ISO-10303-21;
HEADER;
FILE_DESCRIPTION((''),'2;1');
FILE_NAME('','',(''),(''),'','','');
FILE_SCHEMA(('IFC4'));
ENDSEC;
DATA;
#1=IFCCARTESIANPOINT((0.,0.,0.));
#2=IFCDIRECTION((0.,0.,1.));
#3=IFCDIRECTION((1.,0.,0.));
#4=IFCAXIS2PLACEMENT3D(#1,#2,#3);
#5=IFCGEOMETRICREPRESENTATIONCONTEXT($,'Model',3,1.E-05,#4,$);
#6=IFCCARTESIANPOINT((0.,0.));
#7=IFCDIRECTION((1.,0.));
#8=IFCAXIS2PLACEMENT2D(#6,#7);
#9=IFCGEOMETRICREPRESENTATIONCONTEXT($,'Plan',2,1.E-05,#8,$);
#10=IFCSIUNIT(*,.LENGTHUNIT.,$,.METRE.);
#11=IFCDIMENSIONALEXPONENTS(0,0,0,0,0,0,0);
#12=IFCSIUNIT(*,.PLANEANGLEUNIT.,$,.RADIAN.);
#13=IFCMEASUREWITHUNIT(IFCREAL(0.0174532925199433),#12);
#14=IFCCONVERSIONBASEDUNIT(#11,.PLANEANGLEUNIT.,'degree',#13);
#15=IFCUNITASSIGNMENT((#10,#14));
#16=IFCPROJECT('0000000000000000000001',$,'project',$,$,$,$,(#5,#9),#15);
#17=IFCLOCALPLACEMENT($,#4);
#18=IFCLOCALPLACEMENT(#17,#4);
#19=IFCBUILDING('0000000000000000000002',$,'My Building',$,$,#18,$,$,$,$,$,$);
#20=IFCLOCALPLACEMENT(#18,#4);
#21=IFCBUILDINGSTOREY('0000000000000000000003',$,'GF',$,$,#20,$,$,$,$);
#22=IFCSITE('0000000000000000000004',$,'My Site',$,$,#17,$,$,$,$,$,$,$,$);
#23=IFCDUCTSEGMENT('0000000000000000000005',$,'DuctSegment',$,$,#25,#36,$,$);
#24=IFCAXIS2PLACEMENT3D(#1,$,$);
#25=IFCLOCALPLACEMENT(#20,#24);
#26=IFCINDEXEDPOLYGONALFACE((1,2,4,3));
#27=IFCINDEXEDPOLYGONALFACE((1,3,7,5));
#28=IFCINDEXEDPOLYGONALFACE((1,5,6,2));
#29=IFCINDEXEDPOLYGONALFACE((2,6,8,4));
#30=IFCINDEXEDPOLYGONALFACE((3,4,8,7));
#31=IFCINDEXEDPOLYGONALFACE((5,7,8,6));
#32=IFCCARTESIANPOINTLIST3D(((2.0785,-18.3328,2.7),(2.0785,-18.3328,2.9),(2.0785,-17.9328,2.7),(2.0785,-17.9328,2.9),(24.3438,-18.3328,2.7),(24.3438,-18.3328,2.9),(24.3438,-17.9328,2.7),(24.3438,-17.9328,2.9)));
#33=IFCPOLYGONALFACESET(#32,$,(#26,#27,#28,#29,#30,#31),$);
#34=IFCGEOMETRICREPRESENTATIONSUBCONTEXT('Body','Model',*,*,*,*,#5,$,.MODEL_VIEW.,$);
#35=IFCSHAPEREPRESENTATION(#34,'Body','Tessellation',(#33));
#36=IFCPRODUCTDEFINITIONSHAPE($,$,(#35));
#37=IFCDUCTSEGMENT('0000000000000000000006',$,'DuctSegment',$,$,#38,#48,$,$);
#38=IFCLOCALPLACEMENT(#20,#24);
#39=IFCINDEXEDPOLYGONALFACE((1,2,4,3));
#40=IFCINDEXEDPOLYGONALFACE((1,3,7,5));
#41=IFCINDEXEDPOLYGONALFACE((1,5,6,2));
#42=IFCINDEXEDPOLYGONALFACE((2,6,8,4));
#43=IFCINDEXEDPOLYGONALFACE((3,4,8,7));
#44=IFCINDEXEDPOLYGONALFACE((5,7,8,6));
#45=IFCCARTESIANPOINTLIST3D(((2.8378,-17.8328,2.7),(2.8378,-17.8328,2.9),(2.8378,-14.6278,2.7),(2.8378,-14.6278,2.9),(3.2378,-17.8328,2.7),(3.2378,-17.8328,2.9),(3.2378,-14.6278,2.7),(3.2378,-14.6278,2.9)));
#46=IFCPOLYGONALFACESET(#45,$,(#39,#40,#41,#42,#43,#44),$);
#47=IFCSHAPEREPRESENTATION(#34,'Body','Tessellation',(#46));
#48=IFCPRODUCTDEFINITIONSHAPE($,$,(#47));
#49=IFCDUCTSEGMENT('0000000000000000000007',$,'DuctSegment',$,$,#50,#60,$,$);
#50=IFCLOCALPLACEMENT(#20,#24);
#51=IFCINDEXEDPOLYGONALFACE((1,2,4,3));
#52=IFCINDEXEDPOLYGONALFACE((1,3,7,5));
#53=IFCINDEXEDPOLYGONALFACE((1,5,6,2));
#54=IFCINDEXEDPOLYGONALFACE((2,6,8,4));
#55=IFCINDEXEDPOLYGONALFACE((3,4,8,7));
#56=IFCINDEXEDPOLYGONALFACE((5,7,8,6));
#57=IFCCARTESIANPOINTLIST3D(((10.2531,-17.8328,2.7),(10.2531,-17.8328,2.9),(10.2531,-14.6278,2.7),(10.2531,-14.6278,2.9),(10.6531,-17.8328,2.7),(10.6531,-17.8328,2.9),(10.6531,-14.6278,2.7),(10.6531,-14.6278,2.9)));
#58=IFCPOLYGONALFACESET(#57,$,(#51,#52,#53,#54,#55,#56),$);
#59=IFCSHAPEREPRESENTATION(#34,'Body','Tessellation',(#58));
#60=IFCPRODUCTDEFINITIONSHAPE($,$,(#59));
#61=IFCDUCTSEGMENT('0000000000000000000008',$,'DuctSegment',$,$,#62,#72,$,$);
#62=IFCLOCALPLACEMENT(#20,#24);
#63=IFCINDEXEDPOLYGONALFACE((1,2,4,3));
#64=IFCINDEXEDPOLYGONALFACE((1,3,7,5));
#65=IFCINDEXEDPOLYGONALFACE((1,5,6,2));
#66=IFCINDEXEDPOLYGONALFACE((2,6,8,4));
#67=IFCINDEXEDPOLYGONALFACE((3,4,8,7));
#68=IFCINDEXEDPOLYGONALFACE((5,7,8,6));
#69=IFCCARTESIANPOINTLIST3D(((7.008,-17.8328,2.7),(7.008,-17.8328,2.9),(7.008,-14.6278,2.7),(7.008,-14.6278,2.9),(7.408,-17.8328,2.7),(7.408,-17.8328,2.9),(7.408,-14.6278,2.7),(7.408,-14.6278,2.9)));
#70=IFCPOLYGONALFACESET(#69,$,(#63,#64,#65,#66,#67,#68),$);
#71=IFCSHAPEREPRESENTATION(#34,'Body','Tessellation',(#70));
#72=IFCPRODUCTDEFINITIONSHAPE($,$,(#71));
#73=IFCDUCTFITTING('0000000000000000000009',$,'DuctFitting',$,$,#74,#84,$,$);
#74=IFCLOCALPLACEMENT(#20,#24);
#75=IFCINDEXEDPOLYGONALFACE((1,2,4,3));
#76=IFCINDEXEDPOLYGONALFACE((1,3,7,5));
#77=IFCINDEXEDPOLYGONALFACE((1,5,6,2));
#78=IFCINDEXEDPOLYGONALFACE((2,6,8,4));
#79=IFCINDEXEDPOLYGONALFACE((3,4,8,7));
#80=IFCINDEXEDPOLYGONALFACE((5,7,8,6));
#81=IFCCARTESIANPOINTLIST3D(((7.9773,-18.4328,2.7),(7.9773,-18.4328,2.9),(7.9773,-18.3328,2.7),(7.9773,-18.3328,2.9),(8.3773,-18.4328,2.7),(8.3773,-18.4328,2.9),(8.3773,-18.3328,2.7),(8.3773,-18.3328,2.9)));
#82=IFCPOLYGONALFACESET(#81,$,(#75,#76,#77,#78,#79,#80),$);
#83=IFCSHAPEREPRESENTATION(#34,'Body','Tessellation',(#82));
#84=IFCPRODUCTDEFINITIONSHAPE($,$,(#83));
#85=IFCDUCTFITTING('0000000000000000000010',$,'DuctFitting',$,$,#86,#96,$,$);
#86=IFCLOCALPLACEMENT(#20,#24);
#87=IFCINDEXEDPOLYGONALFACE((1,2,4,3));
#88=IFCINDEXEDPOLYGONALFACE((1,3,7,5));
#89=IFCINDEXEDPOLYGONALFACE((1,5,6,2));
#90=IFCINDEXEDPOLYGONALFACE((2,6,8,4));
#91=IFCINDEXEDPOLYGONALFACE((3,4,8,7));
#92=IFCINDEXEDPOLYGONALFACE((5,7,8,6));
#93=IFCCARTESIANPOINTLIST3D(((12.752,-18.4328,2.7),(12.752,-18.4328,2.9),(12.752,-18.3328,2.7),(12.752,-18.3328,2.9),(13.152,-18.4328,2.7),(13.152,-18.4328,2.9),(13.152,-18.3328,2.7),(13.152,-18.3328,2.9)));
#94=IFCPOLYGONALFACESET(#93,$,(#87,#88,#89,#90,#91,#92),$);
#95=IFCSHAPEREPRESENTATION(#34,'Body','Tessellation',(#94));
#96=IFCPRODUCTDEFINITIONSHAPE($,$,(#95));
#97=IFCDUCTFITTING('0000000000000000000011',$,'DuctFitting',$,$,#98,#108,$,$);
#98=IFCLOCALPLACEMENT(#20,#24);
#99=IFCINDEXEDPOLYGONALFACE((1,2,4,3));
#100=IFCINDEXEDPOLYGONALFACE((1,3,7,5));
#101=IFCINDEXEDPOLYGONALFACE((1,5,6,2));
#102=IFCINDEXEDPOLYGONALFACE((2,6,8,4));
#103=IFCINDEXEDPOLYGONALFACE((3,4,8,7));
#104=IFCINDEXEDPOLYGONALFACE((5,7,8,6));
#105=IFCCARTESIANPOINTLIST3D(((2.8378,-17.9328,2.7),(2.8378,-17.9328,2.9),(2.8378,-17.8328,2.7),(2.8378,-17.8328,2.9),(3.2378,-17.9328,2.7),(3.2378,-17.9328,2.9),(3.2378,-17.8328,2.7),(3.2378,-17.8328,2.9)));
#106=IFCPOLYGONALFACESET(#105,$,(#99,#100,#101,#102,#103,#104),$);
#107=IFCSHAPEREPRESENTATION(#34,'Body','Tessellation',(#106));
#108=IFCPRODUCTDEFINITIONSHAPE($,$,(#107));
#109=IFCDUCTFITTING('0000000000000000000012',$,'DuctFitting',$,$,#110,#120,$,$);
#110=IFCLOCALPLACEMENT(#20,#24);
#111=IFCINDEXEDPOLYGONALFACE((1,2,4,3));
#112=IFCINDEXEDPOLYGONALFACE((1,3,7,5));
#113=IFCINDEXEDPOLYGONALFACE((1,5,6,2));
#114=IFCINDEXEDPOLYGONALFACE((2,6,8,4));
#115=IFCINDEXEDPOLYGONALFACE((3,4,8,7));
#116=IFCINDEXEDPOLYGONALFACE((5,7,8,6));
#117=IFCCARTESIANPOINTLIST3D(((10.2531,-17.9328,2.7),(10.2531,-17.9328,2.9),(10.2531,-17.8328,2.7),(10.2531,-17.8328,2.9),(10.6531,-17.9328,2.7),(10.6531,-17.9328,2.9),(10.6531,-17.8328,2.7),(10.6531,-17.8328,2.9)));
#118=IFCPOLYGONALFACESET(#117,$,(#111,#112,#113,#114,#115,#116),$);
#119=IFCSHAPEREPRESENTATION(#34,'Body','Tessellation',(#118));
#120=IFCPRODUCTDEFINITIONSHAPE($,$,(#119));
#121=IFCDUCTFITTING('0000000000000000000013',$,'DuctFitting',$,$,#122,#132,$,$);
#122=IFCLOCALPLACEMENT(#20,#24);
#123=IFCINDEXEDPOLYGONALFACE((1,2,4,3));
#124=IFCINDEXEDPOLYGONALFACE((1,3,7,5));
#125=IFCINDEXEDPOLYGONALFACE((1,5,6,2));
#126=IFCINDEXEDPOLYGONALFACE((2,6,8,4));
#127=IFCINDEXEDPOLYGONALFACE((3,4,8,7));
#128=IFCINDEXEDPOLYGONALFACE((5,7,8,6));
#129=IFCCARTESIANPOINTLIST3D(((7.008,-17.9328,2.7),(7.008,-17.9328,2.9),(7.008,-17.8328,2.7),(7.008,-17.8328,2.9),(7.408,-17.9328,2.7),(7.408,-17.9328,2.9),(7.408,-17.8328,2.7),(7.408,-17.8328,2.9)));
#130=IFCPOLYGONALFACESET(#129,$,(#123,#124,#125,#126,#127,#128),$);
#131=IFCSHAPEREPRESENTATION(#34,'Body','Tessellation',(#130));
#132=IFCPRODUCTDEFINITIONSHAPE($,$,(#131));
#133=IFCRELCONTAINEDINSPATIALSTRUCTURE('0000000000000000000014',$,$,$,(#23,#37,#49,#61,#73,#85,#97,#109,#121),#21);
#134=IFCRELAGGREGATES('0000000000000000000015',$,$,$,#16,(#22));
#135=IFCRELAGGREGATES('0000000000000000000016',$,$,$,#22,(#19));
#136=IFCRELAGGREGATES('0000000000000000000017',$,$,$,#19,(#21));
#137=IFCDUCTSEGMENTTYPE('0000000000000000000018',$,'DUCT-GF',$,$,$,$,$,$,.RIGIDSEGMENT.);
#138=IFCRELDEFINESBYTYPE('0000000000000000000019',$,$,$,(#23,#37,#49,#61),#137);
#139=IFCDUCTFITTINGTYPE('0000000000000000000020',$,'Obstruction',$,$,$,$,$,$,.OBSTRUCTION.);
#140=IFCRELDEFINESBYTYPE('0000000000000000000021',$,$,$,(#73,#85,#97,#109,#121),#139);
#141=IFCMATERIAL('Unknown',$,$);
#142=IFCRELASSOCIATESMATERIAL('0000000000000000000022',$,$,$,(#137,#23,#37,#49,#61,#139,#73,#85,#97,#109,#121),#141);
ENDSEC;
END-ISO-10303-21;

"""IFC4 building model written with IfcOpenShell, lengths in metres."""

from ifc_helpers import new_model, entity, si_unit, converted_unit, frame, origin_with_axes, origin_2d_with_axis, place, context, subcontext, project, spatial, rectangle, extrude, material, material_profile, profile_set, profile_usage, type_object, element, save


model = new_model("IFC4")

# Units and contexts
model_context = context("Model", 3, precision=1e-05, world=origin_with_axes())
plan_context = context("Plan", 2, precision=1e-05, world=origin_2d_with_axis())
body_context_1 = subcontext(model_context, "Body", "Model", "MODEL_VIEW")
ifc_project = project(units=[si_unit("LENGTHUNIT", "METRE"), converted_unit("PLANEANGLEUNIT", "degree", entity("IfcReal", 0.0174532925199433), si_unit("PLANEANGLEUNIT", "RADIAN"), dimensions=[0, 0, 0, 0, 0, 0, 0])], contexts=[model_context, plan_context])

# Site, building, storey
site_placement = place(None, origin_with_axes())
site = spatial("IfcSite", under=ifc_project, at=site_placement, Name="My Site")
building_placement = place(site_placement, origin_with_axes())
building = spatial("IfcBuilding", under=site, at=building_placement, Name="My Building")
storey_placement = place(building_placement, origin_with_axes())
storey = spatial("IfcBuildingStorey", under=building, at=storey_placement, Name="GF")

# Shared definitions
ifc_material = material(Name="Unknown")

# Duct segments
ifc_material_profile_1 = material_profile(ifc_material, rectangle(XDim=0.4, YDim=0.2))
ifc_profile_set_1 = profile_set([ifc_material_profile_1])
ifc_profile_usage_1 = profile_usage(ifc_profile_set_1, cardinal=5)
duct_segment_type = type_object("IfcDuctSegmentType", Name="DUCT-GF", PredefinedType="RIGIDSEGMENT", material=ifc_profile_set_1)
duct_segment_1_placement = place(storey_placement, frame((2.0785, -18.1328, 2.8), z_axis=(1.0, 0.0, 0.0), x_axis=(0.0, 1.0, 0.0)))
element("IfcDuctSegment", 1, at=duct_segment_1_placement, inside=storey, type_object=duct_segment_type, material=ifc_profile_usage_1, Name="DuctSegment", context=body_context_1, shape_type="SweptSolid", body=[
    extrude(rectangle(XDim=0.4, YDim=0.2), origin_with_axes(), (0.0, 0.0, 1.0), 22.2653),
])
ifc_profile_usage_2 = profile_usage(ifc_profile_set_1, cardinal=5)
duct_segment_2_placement = place(storey_placement, frame((3.0378, -17.8328, 2.8), z_axis=(0.0, 1.0, 0.0), x_axis=(-1.0, 0.0, 0.0)))
element("IfcDuctSegment", 2, at=duct_segment_2_placement, inside=storey, type_object=duct_segment_type, material=ifc_profile_usage_2, Name="DuctSegment", context=body_context_1, shape_type="SweptSolid", body=[
    extrude(rectangle(XDim=0.4, YDim=0.2), origin_with_axes(), (0.0, 0.0, 1.0), 3.2051),
])
ifc_profile_usage_3 = profile_usage(ifc_profile_set_1, cardinal=5)
duct_segment_3_placement = place(storey_placement, frame((10.4531, -17.8328, 2.8), z_axis=(0.0, 1.0, 0.0), x_axis=(-1.0, 0.0, 0.0)))
element("IfcDuctSegment", 3, at=duct_segment_3_placement, inside=storey, type_object=duct_segment_type, material=ifc_profile_usage_3, Name="DuctSegment", context=body_context_1, shape_type="SweptSolid", body=[
    extrude(rectangle(XDim=0.4, YDim=0.2), origin_with_axes(), (0.0, 0.0, 1.0), 3.2051),
])
ifc_profile_usage_4 = profile_usage(ifc_profile_set_1, cardinal=5)
duct_segment_4_placement = place(storey_placement, frame((7.208, -17.8328, 2.8), z_axis=(0.0, 1.0, 0.0), x_axis=(-1.0, 0.0, 0.0)))
element("IfcDuctSegment", 4, at=duct_segment_4_placement, inside=storey, type_object=duct_segment_type, material=ifc_profile_usage_4, Name="DuctSegment", context=body_context_1, shape_type="SweptSolid", body=[
    extrude(rectangle(XDim=0.4, YDim=0.2), origin_with_axes(), (0.0, 0.0, 1.0), 3.2051),
])

# Duct fittings
ifc_material_profile_2 = material_profile(ifc_material, rectangle(XDim=0.4, YDim=0.2))
ifc_profile_set_2 = profile_set([ifc_material_profile_2])
ifc_profile_usage_5 = profile_usage(ifc_profile_set_2, cardinal=5)
duct_fitting_type = type_object("IfcDuctFittingType", Name="Obstruction", PredefinedType="OBSTRUCTION", material=ifc_profile_set_2)
duct_fitting_1_placement = place(storey_placement, frame((8.1773, -18.3328, 2.8), z_axis=(0.0, -1.0, 0.0), x_axis=(1.0, 0.0, 0.0)))
element("IfcDuctFitting", 5, at=duct_fitting_1_placement, inside=storey, type_object=duct_fitting_type, material=ifc_profile_usage_5, Name="DuctFitting", context=body_context_1, shape_type="SweptSolid", body=[
    extrude(rectangle(XDim=0.4, YDim=0.2), origin_with_axes(), (0.0, 0.0, 1.0), 0.1),
])
ifc_profile_usage_6 = profile_usage(ifc_profile_set_2, cardinal=5)
duct_fitting_2_placement = place(storey_placement, frame((12.952, -18.3328, 2.8), z_axis=(0.0, -1.0, 0.0), x_axis=(1.0, 0.0, 0.0)))
element("IfcDuctFitting", 6, at=duct_fitting_2_placement, inside=storey, type_object=duct_fitting_type, material=ifc_profile_usage_6, Name="DuctFitting", context=body_context_1, shape_type="SweptSolid", body=[
    extrude(rectangle(XDim=0.4, YDim=0.2), origin_with_axes(), (0.0, 0.0, 1.0), 0.1),
])
ifc_profile_usage_7 = profile_usage(ifc_profile_set_2, cardinal=5)
duct_fitting_3_placement = place(storey_placement, frame((3.0378, -17.9328, 2.8), z_axis=(0.0, 1.0, 0.0), x_axis=(-1.0, 0.0, 0.0)))
element("IfcDuctFitting", 7, at=duct_fitting_3_placement, inside=storey, type_object=duct_fitting_type, material=ifc_profile_usage_7, Name="DuctFitting", context=body_context_1, shape_type="SweptSolid", body=[
    extrude(rectangle(XDim=0.4, YDim=0.2), origin_with_axes(), (0.0, 0.0, 1.0), 0.1),
])
ifc_profile_usage_8 = profile_usage(ifc_profile_set_2, cardinal=5)
duct_fitting_4_placement = place(storey_placement, frame((10.4531, -17.9328, 2.8), z_axis=(0.0, 1.0, 0.0), x_axis=(-1.0, 0.0, 0.0)))
element("IfcDuctFitting", 8, at=duct_fitting_4_placement, inside=storey, type_object=duct_fitting_type, material=ifc_profile_usage_8, Name="DuctFitting", context=body_context_1, shape_type="SweptSolid", body=[
    extrude(rectangle(XDim=0.4, YDim=0.2), origin_with_axes(), (0.0, 0.0, 1.0), 0.1),
])
ifc_profile_usage_9 = profile_usage(ifc_profile_set_2, cardinal=5)
duct_fitting_5_placement = place(storey_placement, frame((7.208, -17.9328, 2.8), z_axis=(0.0, 1.0, 0.0), x_axis=(-1.0, 0.0, 0.0)))
element("IfcDuctFitting", 9, at=duct_fitting_5_placement, inside=storey, type_object=duct_fitting_type, material=ifc_profile_usage_9, Name="DuctFitting", context=body_context_1, shape_type="SweptSolid", body=[
    extrude(rectangle(XDim=0.4, YDim=0.2), origin_with_axes(), (0.0, 0.0, 1.0), 0.1),
])

save(model, "model.ifc")
